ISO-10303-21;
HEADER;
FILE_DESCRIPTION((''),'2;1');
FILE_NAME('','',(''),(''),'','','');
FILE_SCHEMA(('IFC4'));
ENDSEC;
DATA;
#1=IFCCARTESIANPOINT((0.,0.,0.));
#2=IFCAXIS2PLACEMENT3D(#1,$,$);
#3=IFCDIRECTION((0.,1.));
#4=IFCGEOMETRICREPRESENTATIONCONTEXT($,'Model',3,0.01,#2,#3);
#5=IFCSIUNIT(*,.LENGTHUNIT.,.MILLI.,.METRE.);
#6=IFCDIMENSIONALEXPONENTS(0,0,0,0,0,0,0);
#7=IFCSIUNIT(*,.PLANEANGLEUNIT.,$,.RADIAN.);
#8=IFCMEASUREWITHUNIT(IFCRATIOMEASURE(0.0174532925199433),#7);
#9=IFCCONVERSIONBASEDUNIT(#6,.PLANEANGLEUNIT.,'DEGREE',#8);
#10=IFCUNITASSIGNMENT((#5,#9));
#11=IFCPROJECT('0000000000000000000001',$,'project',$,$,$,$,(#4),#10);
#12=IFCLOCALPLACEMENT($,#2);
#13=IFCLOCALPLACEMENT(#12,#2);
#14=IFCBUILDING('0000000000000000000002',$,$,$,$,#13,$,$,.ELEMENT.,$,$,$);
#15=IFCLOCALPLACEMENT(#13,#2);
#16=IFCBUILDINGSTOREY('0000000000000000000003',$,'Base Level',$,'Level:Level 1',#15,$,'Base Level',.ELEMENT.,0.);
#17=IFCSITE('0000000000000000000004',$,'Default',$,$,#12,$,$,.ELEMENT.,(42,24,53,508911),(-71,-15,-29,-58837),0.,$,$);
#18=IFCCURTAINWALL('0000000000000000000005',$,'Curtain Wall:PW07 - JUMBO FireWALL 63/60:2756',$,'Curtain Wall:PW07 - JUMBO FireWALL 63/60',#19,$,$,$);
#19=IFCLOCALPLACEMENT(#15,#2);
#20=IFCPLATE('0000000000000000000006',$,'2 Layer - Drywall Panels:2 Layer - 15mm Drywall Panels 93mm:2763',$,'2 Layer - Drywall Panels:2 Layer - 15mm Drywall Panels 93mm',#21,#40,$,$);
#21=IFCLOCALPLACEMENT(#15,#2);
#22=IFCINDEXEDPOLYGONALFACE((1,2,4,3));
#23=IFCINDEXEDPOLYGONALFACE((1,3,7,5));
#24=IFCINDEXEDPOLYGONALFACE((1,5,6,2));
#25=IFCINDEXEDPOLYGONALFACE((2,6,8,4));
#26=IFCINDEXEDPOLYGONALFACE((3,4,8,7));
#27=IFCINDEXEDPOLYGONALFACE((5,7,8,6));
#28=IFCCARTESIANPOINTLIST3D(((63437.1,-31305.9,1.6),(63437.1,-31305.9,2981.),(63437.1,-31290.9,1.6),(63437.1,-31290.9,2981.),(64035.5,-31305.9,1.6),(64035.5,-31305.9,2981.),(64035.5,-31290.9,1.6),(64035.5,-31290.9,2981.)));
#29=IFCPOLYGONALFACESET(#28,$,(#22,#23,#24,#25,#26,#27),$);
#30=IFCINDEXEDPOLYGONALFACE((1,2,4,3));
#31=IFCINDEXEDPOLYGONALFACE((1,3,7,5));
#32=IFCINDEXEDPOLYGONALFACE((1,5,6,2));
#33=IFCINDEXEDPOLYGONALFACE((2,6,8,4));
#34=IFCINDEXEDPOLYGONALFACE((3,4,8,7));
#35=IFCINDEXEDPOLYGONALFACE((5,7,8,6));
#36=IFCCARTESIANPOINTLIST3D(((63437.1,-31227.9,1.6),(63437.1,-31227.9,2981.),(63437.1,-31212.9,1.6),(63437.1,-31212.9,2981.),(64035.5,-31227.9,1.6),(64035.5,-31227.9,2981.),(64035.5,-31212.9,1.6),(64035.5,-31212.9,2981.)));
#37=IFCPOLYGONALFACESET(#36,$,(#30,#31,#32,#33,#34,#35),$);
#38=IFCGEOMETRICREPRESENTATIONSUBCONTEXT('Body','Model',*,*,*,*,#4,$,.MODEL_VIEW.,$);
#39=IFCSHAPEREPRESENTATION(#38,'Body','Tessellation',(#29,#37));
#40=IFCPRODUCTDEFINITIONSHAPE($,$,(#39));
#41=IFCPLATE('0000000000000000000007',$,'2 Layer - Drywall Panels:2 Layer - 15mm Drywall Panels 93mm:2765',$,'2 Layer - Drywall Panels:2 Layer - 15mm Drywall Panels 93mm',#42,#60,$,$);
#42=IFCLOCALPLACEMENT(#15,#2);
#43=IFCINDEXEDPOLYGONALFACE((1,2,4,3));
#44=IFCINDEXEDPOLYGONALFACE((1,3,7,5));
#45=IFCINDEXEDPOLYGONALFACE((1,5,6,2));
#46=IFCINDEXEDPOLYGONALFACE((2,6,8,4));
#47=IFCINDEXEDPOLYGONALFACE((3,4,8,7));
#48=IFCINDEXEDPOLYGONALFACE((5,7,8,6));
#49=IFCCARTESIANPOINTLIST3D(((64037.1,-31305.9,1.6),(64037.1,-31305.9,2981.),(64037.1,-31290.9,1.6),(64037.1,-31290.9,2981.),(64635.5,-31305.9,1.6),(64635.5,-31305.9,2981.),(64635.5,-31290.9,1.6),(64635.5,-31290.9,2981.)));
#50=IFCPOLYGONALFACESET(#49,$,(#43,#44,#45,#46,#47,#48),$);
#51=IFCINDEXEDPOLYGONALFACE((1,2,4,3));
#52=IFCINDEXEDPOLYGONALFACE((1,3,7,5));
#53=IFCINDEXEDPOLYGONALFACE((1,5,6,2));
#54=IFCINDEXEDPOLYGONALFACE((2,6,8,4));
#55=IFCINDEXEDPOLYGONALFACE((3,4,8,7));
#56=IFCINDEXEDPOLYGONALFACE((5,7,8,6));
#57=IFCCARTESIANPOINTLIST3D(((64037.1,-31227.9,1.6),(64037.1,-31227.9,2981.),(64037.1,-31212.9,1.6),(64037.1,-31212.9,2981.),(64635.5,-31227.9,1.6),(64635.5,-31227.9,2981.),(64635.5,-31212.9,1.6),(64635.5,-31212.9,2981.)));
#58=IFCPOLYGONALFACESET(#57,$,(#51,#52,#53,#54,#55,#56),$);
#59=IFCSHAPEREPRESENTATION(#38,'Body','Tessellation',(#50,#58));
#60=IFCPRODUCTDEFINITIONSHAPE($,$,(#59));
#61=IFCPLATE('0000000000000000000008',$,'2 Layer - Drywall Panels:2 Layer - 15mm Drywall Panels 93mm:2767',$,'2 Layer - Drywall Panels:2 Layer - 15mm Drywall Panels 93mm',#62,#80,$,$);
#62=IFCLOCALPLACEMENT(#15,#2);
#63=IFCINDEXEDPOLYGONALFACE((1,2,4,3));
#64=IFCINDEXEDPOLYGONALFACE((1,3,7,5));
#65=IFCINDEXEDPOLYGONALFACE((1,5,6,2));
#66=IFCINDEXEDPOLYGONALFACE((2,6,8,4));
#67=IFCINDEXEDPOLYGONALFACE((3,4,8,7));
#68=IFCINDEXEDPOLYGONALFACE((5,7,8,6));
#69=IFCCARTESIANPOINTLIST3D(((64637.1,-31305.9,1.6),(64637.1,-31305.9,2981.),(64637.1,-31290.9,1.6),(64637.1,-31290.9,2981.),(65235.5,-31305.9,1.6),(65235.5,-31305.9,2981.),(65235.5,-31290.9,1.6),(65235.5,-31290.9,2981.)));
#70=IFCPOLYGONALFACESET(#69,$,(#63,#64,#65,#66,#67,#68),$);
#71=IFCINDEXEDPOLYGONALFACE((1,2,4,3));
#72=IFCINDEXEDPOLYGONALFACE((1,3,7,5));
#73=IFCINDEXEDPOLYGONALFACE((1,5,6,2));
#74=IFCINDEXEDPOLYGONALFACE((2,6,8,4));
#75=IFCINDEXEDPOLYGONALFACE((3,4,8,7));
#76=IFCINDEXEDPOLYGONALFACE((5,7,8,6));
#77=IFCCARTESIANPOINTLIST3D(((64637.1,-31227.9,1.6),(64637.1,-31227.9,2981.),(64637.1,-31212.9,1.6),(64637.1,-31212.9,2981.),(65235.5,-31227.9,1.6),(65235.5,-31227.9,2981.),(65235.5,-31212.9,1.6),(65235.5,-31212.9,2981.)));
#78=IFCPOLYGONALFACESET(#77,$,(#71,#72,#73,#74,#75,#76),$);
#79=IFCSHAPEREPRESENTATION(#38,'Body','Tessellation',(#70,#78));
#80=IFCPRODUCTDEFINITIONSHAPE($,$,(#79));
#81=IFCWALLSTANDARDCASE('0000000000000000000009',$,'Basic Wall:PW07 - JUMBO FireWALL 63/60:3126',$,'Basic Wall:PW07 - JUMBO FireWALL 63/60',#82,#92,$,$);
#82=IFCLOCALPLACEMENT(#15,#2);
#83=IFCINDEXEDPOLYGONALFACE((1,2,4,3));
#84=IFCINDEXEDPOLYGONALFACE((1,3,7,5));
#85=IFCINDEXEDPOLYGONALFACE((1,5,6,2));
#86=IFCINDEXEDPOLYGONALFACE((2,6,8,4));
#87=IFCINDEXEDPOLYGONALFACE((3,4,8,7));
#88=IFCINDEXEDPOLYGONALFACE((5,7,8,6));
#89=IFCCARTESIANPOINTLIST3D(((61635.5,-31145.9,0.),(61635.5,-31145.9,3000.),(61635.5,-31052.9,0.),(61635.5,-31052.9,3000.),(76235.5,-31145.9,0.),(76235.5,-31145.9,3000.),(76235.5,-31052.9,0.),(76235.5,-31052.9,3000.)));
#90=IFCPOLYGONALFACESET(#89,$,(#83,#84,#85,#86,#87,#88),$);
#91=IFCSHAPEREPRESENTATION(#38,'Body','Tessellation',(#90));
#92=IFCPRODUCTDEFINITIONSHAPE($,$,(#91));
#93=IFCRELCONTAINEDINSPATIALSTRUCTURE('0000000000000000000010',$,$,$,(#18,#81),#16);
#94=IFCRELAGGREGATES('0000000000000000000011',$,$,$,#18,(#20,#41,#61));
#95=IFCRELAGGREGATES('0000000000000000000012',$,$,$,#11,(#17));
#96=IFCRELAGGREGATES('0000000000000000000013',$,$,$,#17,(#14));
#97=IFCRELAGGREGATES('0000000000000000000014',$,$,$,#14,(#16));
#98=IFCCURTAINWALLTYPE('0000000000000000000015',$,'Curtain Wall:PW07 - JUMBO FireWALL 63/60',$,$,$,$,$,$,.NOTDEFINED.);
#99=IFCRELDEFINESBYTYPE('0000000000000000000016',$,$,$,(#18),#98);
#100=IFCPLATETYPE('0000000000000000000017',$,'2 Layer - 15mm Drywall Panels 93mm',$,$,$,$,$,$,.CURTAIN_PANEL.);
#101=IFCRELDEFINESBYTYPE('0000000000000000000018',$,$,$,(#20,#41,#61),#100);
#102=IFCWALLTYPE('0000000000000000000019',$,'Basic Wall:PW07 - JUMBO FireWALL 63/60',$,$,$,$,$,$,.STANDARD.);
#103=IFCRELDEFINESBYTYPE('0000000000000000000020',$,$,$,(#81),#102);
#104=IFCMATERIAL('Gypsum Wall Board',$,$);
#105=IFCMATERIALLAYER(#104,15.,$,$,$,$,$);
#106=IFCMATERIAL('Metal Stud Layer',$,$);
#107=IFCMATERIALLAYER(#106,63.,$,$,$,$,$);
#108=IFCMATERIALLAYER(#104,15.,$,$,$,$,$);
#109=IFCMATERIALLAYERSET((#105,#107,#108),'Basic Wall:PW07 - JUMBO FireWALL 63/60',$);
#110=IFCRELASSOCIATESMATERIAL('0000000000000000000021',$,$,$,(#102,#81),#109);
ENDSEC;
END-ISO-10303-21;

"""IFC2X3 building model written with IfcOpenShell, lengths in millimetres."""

from ifc_helpers import new_model, entity, si_unit, converted_unit, direction, frame, frame_2d, origin, place, context, subcontext, project, spatial, rectangle, extrude, source, transform, mapped, material, layer, layer_set, layer_usage, type_object, type_shapes, element, aggregate, save


model = new_model("IFC2X3")

# Units and contexts
model_context = context("Model", 3, precision=0.01, world=origin(), true_north=direction((0.0, 1.0)))
body_context = subcontext(model_context, "Body", "Model", "MODEL_VIEW")
ifc_project = project(units=[si_unit("LENGTHUNIT", "METRE", prefix="MILLI"), converted_unit("PLANEANGLEUNIT", "DEGREE", entity("IfcRatioMeasure", 0.0174532925199433), si_unit("PLANEANGLEUNIT", "RADIAN"), dimensions=[0, 0, 0, 0, 0, 0, 0])], contexts=[model_context])

# Site, building, storey
site_placement = place(None, origin())
site = spatial("IfcSite", under=ifc_project, at=site_placement, Name="Default", CompositionType="ELEMENT", RefLatitude=(42, 24, 53, 508911), RefLongitude=(-71, -15, -29, -58837), RefElevation=0.0)
building_placement = place(site_placement, origin())
building = spatial("IfcBuilding", under=site, at=building_placement, CompositionType="ELEMENT")
storey_placement = place(building_placement, origin())
storey = spatial("IfcBuildingStorey", under=building, at=storey_placement, Name="Base Level", ObjectType="Level:Level 1", LongName="Base Level", CompositionType="ELEMENT", Elevation=0.0)

# Curtain wall, plates
curtain_wall_type = type_object("IfcCurtainWallType", Name="Curtain Wall:PW07 - JUMBO FireWALL 63/60", PredefinedType="NOTDEFINED")
curtain_wall_placement = place(building_placement, origin())
curtain_wall = element("IfcCurtainWall", 1, at=curtain_wall_placement, inside=storey, type_object=curtain_wall_type, Name="Curtain Wall:PW07 - JUMBO FireWALL 63/60:2756", ObjectType="Curtain Wall:PW07 - JUMBO FireWALL 63/60")
plate_type = type_object("IfcPlateType", Name="2 Layer - 15mm Drywall Panels 93mm", PredefinedType="CURTAIN_PANEL")
shared_shape_1 = source(origin(), body_context, "Body", "SweptSolid", [
    extrude(rectangle(XDim=598.4, YDim=15.0, at=frame_2d((0.0, 0.0), x_axis=(1.0, 0.0))), frame((0.0, -39.0, 0.0), z_axis=(0.0, 0.0, 1.0), x_axis=(-1.0, 0.0, 0.0)), (0.0, 0.0, 1.0), 2979.4),
    extrude(rectangle(XDim=15.0, YDim=598.4, at=frame_2d((0.0, 0.0), x_axis=(1.0, 0.0))), frame((0.0, 39.0, 0.0), z_axis=(0.0, 0.0, 1.0), x_axis=(0.0, 1.0, 0.0)), (0.0, 0.0, 1.0), 2979.4),
])
type_shapes(plate_type, [shared_shape_1])
plate_1_placement = place(curtain_wall_placement, frame((63736.3, -31259.4, 1.6)))
plate_1 = element("IfcPlate", 2, at=plate_1_placement, type_object=plate_type, Name="2 Layer - Drywall Panels:2 Layer - 15mm Drywall Panels 93mm:2763", ObjectType="2 Layer - Drywall Panels:2 Layer - 15mm Drywall Panels 93mm", context=body_context, shape_type="MappedRepresentation", body=[
    mapped(shared_shape_1, transform((0.0, 0.0, 0.0), scale=1.0)),
])
plate_2_placement = place(curtain_wall_placement, frame((64336.3, -31259.4, 1.6)))
plate_2 = element("IfcPlate", 3, at=plate_2_placement, type_object=plate_type, Name="2 Layer - Drywall Panels:2 Layer - 15mm Drywall Panels 93mm:2765", ObjectType="2 Layer - Drywall Panels:2 Layer - 15mm Drywall Panels 93mm", context=body_context, shape_type="MappedRepresentation", body=[
    mapped(shared_shape_1, transform((0.0, 0.0, 0.0), scale=1.0)),
])
plate_3_placement = place(curtain_wall_placement, frame((64936.3, -31259.4, 1.6)))
plate_3 = element("IfcPlate", 4, at=plate_3_placement, type_object=plate_type, Name="2 Layer - Drywall Panels:2 Layer - 15mm Drywall Panels 93mm:2767", ObjectType="2 Layer - Drywall Panels:2 Layer - 15mm Drywall Panels 93mm", context=body_context, shape_type="MappedRepresentation", body=[
    mapped(shared_shape_1, transform((0.0, 0.0, 0.0), scale=1.0)),
])
aggregate(curtain_wall, [plate_1, plate_2, plate_3])

# Wall
ifc_material_1 = material(Name="Gypsum Wall Board")
ifc_layer_1 = layer(ifc_material_1, 15.0)
ifc_material_2 = material(Name="Metal Stud Layer")
ifc_layer_2 = layer(ifc_material_2, 63.0)
ifc_layer_3 = layer(ifc_material_1, 15.0)
ifc_layer_set = layer_set([ifc_layer_1, ifc_layer_2, ifc_layer_3], Name="Basic Wall:PW07 - JUMBO FireWALL 63/60")
ifc_layer_usage = layer_usage(ifc_layer_set, "AXIS2", "NEGATIVE", 46.5)
wall_type = type_object("IfcWallType", Name="Basic Wall:PW07 - JUMBO FireWALL 63/60", PredefinedType="STANDARD", material=ifc_layer_set)
wall_placement = place(building_placement, frame((61635.5, -31099.4, 0.0)))
element("IfcWallStandardCase", 5, at=wall_placement, inside=storey, type_object=wall_type, material=ifc_layer_usage, Name="Basic Wall:PW07 - JUMBO FireWALL 63/60:3126", ObjectType="Basic Wall:PW07 - JUMBO FireWALL 63/60", context=body_context, shape_type="SweptSolid", body=[
    extrude(rectangle(XDim=14600.0, YDim=93.0, at=frame_2d((7300.0, 0.0), x_axis=(-1.0, 0.0))), origin(), (0.0, 0.0, 1.0), 3000.0),
])

save(model, "model.ifc")
